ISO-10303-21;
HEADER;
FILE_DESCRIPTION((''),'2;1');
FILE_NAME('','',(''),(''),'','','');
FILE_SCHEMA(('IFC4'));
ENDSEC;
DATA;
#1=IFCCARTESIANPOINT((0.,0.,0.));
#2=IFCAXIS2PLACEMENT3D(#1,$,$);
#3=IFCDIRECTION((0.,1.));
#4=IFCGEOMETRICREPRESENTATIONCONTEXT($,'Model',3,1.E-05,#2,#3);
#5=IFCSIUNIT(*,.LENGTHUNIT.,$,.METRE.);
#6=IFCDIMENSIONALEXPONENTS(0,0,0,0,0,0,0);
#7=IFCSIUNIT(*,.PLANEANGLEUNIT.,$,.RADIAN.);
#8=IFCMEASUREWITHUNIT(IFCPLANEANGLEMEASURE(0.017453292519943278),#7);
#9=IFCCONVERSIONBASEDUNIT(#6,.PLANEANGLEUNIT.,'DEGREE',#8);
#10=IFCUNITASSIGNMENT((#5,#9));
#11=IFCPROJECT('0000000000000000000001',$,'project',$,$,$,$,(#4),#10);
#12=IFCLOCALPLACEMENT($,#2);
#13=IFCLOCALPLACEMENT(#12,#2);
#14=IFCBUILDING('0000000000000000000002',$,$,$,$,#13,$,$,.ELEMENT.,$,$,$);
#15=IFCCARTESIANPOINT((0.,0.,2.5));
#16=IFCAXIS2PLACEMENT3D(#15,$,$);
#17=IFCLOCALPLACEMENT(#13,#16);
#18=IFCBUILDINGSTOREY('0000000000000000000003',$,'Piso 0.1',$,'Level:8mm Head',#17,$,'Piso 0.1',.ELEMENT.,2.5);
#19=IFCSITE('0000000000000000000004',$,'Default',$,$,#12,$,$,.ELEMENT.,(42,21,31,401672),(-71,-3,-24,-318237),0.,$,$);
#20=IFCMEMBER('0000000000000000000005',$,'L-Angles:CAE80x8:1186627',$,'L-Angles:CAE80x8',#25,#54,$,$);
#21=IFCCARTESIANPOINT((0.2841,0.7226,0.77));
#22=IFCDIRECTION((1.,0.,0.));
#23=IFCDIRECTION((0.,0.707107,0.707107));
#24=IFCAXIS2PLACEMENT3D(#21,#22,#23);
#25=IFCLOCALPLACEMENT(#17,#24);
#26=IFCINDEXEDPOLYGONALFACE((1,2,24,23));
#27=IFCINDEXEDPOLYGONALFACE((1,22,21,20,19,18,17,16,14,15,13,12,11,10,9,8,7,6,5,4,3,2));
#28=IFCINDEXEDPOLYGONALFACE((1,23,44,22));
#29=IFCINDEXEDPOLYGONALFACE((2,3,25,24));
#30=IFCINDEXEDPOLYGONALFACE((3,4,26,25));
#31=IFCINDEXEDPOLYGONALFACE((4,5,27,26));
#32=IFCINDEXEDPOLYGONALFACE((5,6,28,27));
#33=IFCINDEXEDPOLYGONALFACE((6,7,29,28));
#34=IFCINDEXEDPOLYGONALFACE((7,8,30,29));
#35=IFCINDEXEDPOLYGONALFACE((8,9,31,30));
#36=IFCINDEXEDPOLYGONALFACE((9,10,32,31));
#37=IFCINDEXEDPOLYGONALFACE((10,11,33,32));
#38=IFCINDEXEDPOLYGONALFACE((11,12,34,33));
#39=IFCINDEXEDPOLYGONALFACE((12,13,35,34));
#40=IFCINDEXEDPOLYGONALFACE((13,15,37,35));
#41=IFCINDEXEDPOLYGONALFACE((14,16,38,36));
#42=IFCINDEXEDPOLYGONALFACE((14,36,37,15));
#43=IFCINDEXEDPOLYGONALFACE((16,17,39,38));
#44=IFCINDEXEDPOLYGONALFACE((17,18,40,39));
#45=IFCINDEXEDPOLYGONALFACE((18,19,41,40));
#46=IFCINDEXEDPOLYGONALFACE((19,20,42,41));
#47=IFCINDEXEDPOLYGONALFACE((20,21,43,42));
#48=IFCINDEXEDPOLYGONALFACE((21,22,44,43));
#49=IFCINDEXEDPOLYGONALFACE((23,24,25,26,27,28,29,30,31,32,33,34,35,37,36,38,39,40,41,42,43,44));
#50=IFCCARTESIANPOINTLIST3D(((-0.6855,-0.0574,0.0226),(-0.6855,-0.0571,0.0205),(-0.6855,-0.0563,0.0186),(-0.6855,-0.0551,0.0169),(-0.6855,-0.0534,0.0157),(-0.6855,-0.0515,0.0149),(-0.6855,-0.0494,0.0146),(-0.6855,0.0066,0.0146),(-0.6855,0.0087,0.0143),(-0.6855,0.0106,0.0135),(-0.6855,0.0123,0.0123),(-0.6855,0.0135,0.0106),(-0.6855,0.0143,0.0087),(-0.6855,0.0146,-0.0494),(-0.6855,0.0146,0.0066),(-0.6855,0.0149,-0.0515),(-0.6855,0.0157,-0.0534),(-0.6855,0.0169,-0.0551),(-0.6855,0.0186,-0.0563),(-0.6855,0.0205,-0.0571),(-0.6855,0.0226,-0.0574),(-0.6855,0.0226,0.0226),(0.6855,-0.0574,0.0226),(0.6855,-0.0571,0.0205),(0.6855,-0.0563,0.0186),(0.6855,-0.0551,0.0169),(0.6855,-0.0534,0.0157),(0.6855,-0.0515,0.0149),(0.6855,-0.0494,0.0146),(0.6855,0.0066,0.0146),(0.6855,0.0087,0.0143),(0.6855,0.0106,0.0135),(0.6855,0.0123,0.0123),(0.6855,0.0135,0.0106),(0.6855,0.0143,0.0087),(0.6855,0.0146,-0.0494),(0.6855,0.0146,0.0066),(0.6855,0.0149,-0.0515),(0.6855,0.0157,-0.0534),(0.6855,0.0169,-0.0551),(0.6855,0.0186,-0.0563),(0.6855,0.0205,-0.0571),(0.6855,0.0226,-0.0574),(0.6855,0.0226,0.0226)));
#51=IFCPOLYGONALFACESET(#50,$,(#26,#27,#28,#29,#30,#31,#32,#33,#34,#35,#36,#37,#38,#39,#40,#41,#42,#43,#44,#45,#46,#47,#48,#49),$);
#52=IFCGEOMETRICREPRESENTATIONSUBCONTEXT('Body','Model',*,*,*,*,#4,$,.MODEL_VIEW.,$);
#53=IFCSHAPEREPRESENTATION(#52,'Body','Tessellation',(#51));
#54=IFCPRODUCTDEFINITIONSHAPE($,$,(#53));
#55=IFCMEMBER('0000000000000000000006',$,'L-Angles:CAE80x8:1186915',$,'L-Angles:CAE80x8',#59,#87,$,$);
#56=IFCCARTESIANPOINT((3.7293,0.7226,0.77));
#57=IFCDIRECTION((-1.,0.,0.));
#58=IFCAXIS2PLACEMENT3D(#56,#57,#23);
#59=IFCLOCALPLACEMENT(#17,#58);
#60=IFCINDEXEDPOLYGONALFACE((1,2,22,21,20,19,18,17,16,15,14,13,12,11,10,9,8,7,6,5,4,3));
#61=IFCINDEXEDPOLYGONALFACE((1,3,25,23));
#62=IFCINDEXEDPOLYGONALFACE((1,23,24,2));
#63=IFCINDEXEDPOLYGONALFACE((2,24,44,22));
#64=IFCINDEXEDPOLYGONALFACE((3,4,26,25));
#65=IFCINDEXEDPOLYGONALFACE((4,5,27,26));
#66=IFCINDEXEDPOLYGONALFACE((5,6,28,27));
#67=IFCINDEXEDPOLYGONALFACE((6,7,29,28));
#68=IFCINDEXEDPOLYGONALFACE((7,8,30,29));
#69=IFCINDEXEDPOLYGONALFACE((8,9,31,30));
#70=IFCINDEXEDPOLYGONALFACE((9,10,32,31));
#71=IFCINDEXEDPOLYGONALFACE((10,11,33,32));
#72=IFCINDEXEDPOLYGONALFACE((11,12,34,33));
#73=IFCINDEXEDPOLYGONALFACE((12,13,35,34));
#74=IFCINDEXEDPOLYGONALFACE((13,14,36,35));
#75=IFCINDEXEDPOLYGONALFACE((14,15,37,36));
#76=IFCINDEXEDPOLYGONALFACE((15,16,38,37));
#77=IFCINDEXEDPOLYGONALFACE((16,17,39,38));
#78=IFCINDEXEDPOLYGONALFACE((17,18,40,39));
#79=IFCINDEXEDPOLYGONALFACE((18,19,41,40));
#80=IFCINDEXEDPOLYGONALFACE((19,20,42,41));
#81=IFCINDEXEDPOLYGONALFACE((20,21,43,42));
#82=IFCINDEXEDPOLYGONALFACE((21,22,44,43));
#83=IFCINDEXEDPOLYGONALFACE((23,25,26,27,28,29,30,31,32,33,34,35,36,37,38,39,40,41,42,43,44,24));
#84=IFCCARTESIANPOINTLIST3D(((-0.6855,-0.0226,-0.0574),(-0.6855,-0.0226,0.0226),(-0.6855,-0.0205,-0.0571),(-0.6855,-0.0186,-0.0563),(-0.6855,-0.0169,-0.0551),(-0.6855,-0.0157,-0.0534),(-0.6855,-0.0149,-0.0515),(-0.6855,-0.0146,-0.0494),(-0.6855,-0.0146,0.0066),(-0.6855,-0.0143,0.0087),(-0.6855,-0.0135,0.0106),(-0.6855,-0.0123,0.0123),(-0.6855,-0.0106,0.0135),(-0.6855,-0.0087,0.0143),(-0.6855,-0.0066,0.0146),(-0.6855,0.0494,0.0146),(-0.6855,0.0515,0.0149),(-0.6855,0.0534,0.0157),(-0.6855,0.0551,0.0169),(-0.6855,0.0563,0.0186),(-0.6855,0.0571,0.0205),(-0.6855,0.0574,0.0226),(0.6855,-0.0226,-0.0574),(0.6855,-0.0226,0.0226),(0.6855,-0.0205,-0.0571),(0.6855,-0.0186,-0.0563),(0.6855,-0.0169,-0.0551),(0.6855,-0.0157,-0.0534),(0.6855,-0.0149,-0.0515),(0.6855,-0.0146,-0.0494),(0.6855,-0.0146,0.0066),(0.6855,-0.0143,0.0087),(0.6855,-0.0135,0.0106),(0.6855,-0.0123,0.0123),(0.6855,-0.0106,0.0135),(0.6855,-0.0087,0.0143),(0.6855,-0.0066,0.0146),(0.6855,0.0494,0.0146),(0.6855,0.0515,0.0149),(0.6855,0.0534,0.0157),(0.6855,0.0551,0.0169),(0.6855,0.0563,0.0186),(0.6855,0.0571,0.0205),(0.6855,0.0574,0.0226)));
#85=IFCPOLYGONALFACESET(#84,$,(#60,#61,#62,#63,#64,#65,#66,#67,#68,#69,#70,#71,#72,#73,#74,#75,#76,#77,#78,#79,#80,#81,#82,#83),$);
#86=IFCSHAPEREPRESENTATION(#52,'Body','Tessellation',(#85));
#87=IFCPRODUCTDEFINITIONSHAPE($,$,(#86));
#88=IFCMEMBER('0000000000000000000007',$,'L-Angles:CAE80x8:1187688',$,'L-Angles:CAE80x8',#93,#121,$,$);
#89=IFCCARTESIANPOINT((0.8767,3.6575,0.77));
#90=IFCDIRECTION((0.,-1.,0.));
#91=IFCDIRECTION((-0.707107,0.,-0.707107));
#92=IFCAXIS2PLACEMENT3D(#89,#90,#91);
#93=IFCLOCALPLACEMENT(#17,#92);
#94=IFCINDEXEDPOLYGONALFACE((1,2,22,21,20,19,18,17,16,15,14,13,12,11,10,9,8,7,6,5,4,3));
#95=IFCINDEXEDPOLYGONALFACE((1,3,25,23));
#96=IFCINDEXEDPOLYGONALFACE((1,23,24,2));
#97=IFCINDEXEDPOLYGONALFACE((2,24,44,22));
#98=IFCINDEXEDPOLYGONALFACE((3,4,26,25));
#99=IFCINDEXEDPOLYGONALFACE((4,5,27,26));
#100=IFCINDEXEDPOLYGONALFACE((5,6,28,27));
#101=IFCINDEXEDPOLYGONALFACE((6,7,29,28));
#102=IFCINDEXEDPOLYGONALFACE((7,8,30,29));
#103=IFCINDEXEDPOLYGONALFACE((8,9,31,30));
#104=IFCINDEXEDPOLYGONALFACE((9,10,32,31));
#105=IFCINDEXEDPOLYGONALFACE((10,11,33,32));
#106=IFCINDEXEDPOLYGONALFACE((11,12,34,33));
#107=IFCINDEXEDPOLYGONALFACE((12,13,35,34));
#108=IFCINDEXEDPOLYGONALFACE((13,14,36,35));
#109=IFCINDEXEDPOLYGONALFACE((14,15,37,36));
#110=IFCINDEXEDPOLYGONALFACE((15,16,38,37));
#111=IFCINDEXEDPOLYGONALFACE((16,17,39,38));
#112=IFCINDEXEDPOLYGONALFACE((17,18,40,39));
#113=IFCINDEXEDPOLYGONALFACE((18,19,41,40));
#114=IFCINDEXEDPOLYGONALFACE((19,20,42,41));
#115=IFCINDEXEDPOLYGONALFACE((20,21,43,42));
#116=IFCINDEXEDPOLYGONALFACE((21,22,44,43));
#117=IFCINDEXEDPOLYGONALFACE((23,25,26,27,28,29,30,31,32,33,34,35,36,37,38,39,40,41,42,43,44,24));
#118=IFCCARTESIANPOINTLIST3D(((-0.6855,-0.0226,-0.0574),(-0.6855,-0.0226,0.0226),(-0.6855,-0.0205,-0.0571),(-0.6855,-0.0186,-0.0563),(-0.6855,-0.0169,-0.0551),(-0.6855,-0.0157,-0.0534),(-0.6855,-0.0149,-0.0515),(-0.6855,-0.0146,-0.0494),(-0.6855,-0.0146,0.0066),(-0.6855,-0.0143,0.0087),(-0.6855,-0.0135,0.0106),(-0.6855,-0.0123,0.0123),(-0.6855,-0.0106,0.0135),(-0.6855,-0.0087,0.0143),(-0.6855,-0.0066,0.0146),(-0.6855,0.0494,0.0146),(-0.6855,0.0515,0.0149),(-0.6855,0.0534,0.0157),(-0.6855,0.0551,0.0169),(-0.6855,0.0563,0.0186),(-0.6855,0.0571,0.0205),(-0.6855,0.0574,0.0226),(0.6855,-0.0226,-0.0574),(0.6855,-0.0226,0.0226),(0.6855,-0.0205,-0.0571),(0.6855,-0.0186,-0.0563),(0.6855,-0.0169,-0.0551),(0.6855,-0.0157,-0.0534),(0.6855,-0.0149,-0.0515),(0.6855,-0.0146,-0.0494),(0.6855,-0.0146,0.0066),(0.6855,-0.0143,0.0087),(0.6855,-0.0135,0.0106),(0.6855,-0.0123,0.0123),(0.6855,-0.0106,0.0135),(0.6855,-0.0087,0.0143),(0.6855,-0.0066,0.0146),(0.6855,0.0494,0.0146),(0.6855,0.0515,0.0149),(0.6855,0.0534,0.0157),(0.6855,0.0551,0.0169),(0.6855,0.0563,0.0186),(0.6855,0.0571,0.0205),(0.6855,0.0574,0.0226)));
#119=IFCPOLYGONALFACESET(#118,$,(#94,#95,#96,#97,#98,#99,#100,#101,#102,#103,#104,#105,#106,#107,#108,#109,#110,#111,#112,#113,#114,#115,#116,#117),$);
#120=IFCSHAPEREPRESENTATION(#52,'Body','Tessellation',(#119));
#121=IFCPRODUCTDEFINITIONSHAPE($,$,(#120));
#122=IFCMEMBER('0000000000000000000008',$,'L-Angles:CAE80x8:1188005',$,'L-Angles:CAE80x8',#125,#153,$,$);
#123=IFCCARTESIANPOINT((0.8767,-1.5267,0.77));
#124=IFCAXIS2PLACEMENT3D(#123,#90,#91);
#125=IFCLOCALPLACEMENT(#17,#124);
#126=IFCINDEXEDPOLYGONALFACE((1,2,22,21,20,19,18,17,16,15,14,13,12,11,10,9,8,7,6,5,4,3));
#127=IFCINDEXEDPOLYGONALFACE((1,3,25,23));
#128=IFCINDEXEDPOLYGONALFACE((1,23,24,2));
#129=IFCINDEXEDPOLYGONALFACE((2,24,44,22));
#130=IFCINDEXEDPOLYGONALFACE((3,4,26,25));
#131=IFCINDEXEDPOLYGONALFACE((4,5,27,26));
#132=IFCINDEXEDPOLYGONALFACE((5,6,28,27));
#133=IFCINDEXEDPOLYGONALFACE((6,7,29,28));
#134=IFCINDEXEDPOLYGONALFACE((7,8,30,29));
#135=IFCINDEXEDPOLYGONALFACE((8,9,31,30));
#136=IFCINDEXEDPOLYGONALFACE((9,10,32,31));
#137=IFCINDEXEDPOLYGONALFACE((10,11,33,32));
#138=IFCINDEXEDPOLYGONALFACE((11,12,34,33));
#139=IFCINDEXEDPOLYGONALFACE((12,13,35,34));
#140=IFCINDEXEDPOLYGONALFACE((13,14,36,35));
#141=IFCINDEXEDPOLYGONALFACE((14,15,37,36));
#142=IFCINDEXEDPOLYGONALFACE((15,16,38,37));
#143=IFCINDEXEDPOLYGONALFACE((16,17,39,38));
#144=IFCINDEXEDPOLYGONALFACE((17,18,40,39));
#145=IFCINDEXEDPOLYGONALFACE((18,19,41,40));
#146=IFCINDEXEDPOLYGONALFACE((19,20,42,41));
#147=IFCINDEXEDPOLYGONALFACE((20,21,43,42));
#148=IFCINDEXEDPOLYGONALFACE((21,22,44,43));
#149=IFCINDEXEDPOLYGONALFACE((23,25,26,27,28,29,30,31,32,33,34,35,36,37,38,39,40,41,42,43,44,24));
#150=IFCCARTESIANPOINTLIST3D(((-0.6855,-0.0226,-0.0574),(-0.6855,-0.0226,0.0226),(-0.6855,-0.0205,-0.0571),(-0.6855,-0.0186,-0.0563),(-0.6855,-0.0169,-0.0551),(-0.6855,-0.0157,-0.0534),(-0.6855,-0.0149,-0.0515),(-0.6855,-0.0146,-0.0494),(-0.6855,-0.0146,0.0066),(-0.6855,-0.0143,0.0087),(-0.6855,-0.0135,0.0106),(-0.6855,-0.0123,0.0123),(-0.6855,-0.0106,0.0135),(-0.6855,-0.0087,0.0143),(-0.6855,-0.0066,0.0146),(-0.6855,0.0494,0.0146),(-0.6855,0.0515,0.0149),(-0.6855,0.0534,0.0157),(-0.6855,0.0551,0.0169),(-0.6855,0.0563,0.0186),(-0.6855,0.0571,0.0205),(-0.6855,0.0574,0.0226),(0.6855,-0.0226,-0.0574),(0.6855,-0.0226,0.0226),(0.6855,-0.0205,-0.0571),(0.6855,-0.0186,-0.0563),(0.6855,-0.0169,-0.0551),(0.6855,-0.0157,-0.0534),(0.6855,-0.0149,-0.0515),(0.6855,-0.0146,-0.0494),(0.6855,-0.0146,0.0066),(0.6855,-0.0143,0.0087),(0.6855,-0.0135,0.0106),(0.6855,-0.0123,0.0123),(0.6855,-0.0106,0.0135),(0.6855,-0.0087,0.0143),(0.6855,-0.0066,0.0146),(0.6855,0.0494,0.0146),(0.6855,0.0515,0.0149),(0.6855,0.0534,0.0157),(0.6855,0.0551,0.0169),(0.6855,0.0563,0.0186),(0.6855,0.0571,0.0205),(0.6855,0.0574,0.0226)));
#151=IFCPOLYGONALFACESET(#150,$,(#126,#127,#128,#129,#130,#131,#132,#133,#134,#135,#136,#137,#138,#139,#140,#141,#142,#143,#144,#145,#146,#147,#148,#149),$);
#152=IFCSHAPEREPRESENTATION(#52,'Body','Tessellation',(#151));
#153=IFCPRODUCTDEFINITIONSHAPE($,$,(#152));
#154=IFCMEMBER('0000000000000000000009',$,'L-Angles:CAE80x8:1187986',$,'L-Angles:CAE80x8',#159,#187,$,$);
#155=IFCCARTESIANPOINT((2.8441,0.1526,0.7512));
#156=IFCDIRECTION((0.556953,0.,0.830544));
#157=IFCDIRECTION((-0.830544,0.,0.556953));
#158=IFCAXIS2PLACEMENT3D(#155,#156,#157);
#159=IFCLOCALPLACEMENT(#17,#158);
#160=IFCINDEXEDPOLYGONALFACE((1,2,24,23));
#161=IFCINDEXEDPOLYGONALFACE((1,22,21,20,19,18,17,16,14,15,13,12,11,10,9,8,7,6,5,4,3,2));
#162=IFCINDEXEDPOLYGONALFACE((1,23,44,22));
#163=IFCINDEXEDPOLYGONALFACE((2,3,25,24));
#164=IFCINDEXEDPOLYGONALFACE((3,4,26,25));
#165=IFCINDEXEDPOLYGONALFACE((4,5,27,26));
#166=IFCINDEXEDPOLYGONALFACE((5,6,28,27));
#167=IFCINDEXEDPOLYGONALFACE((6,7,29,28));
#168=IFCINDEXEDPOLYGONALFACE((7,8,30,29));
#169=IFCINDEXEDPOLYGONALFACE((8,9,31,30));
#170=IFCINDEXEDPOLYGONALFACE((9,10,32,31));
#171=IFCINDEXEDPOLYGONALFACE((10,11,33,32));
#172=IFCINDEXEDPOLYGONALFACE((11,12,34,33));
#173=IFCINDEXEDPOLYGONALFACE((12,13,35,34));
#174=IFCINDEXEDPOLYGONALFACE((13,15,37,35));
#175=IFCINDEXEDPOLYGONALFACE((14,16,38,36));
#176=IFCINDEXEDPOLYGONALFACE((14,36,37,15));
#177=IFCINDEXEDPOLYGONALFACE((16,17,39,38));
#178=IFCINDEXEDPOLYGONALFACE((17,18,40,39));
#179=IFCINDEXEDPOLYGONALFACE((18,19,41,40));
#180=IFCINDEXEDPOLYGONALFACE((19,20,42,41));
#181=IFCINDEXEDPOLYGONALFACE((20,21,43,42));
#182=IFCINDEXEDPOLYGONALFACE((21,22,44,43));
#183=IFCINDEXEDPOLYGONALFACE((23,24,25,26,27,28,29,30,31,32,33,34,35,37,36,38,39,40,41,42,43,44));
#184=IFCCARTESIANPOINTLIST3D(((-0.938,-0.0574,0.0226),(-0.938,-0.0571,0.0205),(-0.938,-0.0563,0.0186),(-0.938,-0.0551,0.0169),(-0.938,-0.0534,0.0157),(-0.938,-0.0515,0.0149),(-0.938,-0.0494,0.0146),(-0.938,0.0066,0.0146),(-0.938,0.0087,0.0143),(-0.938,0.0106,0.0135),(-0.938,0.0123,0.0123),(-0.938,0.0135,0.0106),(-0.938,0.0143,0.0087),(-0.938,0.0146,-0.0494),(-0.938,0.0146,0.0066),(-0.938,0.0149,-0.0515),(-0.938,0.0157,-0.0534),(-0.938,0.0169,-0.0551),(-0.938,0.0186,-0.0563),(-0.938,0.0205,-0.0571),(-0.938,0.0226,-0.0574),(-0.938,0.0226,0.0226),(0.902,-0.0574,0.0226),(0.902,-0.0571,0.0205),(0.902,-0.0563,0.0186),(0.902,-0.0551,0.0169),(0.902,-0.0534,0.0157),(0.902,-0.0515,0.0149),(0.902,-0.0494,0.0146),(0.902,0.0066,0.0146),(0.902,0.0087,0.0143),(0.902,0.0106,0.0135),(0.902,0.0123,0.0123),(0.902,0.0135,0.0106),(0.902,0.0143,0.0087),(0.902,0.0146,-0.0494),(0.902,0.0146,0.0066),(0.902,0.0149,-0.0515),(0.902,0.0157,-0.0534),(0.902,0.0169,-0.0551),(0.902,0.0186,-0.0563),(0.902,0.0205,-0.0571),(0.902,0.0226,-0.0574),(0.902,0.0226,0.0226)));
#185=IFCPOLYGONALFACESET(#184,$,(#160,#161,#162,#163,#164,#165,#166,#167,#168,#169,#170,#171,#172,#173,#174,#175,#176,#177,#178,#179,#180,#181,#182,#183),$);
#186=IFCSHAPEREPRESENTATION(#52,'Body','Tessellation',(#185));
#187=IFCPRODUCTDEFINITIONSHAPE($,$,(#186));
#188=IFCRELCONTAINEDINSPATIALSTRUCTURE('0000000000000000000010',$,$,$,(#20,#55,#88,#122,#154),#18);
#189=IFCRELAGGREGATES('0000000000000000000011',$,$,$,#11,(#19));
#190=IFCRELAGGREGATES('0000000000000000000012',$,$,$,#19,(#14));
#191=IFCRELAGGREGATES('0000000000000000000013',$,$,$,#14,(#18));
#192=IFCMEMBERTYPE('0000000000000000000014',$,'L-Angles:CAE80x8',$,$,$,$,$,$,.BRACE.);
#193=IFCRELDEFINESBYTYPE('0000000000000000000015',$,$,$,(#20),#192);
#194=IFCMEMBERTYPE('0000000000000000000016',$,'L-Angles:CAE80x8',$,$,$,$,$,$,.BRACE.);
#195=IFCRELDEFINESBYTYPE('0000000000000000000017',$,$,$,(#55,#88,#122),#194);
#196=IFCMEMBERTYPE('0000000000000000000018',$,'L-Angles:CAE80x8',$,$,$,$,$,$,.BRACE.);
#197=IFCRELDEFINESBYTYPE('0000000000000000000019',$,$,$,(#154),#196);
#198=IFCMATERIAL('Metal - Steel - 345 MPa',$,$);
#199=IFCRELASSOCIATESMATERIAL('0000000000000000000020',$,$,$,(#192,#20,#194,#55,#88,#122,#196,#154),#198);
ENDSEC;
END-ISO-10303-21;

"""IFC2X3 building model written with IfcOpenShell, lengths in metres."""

from ifc_helpers import new_model, entity, si_unit, converted_unit, direction, frame, frame_2d, origin, place, context, subcontext, project, spatial, polyline, circle_curve, parameter, trimmed, segment, composite_curve, outline, extrude, source, transform, mapped, material, type_object, type_shapes, element, save


model = new_model("IFC2X3")

# Units and contexts
model_context = context("Model", 3, precision=1e-05, world=origin(), true_north=direction((0.0, 1.0)))
body_context = subcontext(model_context, "Body", "Model", "MODEL_VIEW")
ifc_project = project(units=[si_unit("LENGTHUNIT", "METRE"), converted_unit("PLANEANGLEUNIT", "DEGREE", entity("IfcPlaneAngleMeasure", 0.017453292519943278), si_unit("PLANEANGLEUNIT", "RADIAN"), dimensions=[0, 0, 0, 0, 0, 0, 0])], contexts=[model_context])

# Site, building, storey
site_placement = place(None, origin())
site = spatial("IfcSite", under=ifc_project, at=site_placement, Name="Default", CompositionType="ELEMENT", RefLatitude=(42, 21, 31, 401672), RefLongitude=(-71, -3, -24, -318237), RefElevation=0.0)
building_placement = place(site_placement, origin())
building = spatial("IfcBuilding", under=site, at=building_placement, CompositionType="ELEMENT")
storey_placement = place(building_placement, frame((0.0, 0.0, 2.5)))
storey = spatial("IfcBuildingStorey", under=building, at=storey_placement, Name="Piso 0.1", ObjectType="Level:8mm Head", LongName="Piso 0.1", CompositionType="ELEMENT", Elevation=2.5)

# Shared definitions
ifc_material_1 = material(Name="Metal - Steel - 345 MPa")

# Members
member_type_1 = type_object("IfcMemberType", Name="L-Angles:CAE80x8", PredefinedType="BRACE", material=ifc_material_1)
shared_shape_1 = source(origin(), body_context, "Body", "SweptSolid", [
    extrude(outline(composite_curve([segment(polyline([(-0.0263, -0.0263), (0.0537, -0.0263)]), True, "CONTINUOUS"), segment(trimmed(circle_curve(frame_2d((0.0457, -0.0263), x_axis=(1.0, 0.0)), 0.008), [parameter(0.0)], [parameter(90.0)], True, "PARAMETER"), True, "CONTINUOUS"), segment(polyline([(0.0457, -0.0183), (-0.0103, -0.0183)]), True, "CONTINUOUS"), segment(trimmed(circle_curve(frame_2d((-0.0103, -0.0103), x_axis=(1.0, 0.0)), 0.008), [parameter(180.0)], [parameter(270.0)], True, "PARAMETER"), False, "CONTINUOUS"), segment(polyline([(-0.0183, -0.0103), (-0.0183, 0.0457)]), True, "CONTINUOUS"), segment(trimmed(circle_curve(frame_2d((-0.0263, 0.0457), x_axis=(1.0, 0.0)), 0.008), [parameter(0.0)], [parameter(90.0)], True, "PARAMETER"), True, "CONTINUOUS"), segment(polyline([(-0.0263, 0.0537), (-0.0263, -0.0263)]), True, "CONTINUOUS")], self_intersect=False)), frame((-0.6855, -0.0037, -0.0037), z_axis=(1.0, 0.0, 0.0), x_axis=(0.0, -1.0, 0.0)), (0.0, 0.0, 1.0), 1.371),
])
type_shapes(member_type_1, [shared_shape_1])
member_1_placement = place(storey_placement, frame((0.2841, 0.7226, 0.77), z_axis=(1.0, 0.0, 0.0), x_axis=(0.0, 0.707107, 0.707107)))
element("IfcMember", 1, at=member_1_placement, inside=storey, type_object=member_type_1, material=ifc_material_1, Name="L-Angles:CAE80x8:1186627", ObjectType="L-Angles:CAE80x8", context=body_context, shape_type="MappedRepresentation", body=[
    mapped(shared_shape_1, transform((0.0, 0.0, 0.0), scale=1.0)),
])
member_type_2 = type_object("IfcMemberType", Name="L-Angles:CAE80x8", PredefinedType="BRACE", material=ifc_material_1)
shared_shape_2 = source(origin(), body_context, "Body", "SweptSolid", [
    extrude(outline(composite_curve([segment(polyline([(-0.0263, -0.0263), (0.0537, -0.0263)]), True, "CONTINUOUS"), segment(trimmed(circle_curve(frame_2d((0.0457, -0.0263), x_axis=(0.0, 1.0)), 0.008), [parameter(270.0)], [parameter(0.0)], True, "PARAMETER"), True, "CONTINUOUS"), segment(polyline([(0.0457, -0.0183), (-0.0103, -0.0183)]), True, "CONTINUOUS"), segment(trimmed(circle_curve(frame_2d((-0.0103, -0.0103), x_axis=(0.0, 1.0)), 0.008), [parameter(90.0)], [parameter(180.0)], True, "PARAMETER"), False, "CONTINUOUS"), segment(polyline([(-0.0183, -0.0103), (-0.0183, 0.0457)]), True, "CONTINUOUS"), segment(trimmed(circle_curve(frame_2d((-0.0263, 0.0457), x_axis=(0.0, 1.0)), 0.008), [parameter(270.0)], [parameter(360.0)], True, "PARAMETER"), True, "CONTINUOUS"), segment(polyline([(-0.0263, 0.0537), (-0.0263, -0.0263)]), True, "CONTINUOUS")], self_intersect=False)), frame((-0.6855, 0.0037, -0.0037), z_axis=(1.0, 0.0, 0.0), x_axis=(0.0, 0.0, -1.0)), (0.0, 0.0, 1.0), 1.371),
])
type_shapes(member_type_2, [shared_shape_2])
for number, where, z_axis, x_axis, name in (
    (2, (3.7293, 0.7226, 0.77), (-1.0, 0.0, 0.0), (0.0, 0.707107, 0.707107), "L-Angles:CAE80x8:1186915"),
    (3, (0.8767, 3.6575, 0.77), (0.0, -1.0, 0.0), (-0.707107, 0.0, -0.707107), "L-Angles:CAE80x8:1187688"),
    (4, (0.8767, -1.5267, 0.77), (0.0, -1.0, 0.0), (-0.707107, 0.0, -0.707107), "L-Angles:CAE80x8:1188005"),
):
    element("IfcMember", number, at=place(storey_placement, frame(where, z_axis=z_axis, x_axis=x_axis)), inside=storey, type_object=member_type_2, material=ifc_material_1, Name=name, ObjectType="L-Angles:CAE80x8", context=body_context, shape_type="MappedRepresentation", body=[
        mapped(shared_shape_2, transform((0.0, 0.0, 0.0), scale=1.0)),
    ])
member_type_3 = type_object("IfcMemberType", Name="L-Angles:CAE80x8", PredefinedType="BRACE", material=ifc_material_1)
shared_shape_3 = source(origin(), body_context, "Body", "SweptSolid", [
    extrude(outline(composite_curve([segment(polyline([(-0.0263, -0.0263), (0.0537, -0.0263)]), True, "CONTINUOUS"), segment(trimmed(circle_curve(frame_2d((0.0457, -0.0263), x_axis=(1.0, 0.0)), 0.008), [parameter(0.0)], [parameter(90.0)], True, "PARAMETER"), True, "CONTINUOUS"), segment(polyline([(0.0457, -0.0183), (-0.0103, -0.0183)]), True, "CONTINUOUS"), segment(trimmed(circle_curve(frame_2d((-0.0103, -0.0103), x_axis=(1.0, 0.0)), 0.008), [parameter(180.0)], [parameter(270.0)], True, "PARAMETER"), False, "CONTINUOUS"), segment(polyline([(-0.0183, -0.0103), (-0.0183, 0.0457)]), True, "CONTINUOUS"), segment(trimmed(circle_curve(frame_2d((-0.0263, 0.0457), x_axis=(1.0, 0.0)), 0.008), [parameter(0.0)], [parameter(90.0)], True, "PARAMETER"), True, "CONTINUOUS"), segment(polyline([(-0.0263, 0.0537), (-0.0263, -0.0263)]), True, "CONTINUOUS")], self_intersect=False)), frame((-0.938, -0.0037, -0.0037), z_axis=(1.0, 0.0, 0.0), x_axis=(0.0, -1.0, 0.0)), (0.0, 0.0, 1.0), 1.84),
])
type_shapes(member_type_3, [shared_shape_3])
member_2_placement = place(storey_placement, frame((2.8441, 0.1526, 0.7512), z_axis=(0.556953, 0.0, 0.830544), x_axis=(-0.830544, 0.0, 0.556953)))
element("IfcMember", 5, at=member_2_placement, inside=storey, type_object=member_type_3, material=ifc_material_1, Name="L-Angles:CAE80x8:1187986", ObjectType="L-Angles:CAE80x8", context=body_context, shape_type="MappedRepresentation", body=[
    mapped(shared_shape_3, transform((0.0, 0.0, 0.0), scale=1.0)),
])

save(model, "model.ifc")
